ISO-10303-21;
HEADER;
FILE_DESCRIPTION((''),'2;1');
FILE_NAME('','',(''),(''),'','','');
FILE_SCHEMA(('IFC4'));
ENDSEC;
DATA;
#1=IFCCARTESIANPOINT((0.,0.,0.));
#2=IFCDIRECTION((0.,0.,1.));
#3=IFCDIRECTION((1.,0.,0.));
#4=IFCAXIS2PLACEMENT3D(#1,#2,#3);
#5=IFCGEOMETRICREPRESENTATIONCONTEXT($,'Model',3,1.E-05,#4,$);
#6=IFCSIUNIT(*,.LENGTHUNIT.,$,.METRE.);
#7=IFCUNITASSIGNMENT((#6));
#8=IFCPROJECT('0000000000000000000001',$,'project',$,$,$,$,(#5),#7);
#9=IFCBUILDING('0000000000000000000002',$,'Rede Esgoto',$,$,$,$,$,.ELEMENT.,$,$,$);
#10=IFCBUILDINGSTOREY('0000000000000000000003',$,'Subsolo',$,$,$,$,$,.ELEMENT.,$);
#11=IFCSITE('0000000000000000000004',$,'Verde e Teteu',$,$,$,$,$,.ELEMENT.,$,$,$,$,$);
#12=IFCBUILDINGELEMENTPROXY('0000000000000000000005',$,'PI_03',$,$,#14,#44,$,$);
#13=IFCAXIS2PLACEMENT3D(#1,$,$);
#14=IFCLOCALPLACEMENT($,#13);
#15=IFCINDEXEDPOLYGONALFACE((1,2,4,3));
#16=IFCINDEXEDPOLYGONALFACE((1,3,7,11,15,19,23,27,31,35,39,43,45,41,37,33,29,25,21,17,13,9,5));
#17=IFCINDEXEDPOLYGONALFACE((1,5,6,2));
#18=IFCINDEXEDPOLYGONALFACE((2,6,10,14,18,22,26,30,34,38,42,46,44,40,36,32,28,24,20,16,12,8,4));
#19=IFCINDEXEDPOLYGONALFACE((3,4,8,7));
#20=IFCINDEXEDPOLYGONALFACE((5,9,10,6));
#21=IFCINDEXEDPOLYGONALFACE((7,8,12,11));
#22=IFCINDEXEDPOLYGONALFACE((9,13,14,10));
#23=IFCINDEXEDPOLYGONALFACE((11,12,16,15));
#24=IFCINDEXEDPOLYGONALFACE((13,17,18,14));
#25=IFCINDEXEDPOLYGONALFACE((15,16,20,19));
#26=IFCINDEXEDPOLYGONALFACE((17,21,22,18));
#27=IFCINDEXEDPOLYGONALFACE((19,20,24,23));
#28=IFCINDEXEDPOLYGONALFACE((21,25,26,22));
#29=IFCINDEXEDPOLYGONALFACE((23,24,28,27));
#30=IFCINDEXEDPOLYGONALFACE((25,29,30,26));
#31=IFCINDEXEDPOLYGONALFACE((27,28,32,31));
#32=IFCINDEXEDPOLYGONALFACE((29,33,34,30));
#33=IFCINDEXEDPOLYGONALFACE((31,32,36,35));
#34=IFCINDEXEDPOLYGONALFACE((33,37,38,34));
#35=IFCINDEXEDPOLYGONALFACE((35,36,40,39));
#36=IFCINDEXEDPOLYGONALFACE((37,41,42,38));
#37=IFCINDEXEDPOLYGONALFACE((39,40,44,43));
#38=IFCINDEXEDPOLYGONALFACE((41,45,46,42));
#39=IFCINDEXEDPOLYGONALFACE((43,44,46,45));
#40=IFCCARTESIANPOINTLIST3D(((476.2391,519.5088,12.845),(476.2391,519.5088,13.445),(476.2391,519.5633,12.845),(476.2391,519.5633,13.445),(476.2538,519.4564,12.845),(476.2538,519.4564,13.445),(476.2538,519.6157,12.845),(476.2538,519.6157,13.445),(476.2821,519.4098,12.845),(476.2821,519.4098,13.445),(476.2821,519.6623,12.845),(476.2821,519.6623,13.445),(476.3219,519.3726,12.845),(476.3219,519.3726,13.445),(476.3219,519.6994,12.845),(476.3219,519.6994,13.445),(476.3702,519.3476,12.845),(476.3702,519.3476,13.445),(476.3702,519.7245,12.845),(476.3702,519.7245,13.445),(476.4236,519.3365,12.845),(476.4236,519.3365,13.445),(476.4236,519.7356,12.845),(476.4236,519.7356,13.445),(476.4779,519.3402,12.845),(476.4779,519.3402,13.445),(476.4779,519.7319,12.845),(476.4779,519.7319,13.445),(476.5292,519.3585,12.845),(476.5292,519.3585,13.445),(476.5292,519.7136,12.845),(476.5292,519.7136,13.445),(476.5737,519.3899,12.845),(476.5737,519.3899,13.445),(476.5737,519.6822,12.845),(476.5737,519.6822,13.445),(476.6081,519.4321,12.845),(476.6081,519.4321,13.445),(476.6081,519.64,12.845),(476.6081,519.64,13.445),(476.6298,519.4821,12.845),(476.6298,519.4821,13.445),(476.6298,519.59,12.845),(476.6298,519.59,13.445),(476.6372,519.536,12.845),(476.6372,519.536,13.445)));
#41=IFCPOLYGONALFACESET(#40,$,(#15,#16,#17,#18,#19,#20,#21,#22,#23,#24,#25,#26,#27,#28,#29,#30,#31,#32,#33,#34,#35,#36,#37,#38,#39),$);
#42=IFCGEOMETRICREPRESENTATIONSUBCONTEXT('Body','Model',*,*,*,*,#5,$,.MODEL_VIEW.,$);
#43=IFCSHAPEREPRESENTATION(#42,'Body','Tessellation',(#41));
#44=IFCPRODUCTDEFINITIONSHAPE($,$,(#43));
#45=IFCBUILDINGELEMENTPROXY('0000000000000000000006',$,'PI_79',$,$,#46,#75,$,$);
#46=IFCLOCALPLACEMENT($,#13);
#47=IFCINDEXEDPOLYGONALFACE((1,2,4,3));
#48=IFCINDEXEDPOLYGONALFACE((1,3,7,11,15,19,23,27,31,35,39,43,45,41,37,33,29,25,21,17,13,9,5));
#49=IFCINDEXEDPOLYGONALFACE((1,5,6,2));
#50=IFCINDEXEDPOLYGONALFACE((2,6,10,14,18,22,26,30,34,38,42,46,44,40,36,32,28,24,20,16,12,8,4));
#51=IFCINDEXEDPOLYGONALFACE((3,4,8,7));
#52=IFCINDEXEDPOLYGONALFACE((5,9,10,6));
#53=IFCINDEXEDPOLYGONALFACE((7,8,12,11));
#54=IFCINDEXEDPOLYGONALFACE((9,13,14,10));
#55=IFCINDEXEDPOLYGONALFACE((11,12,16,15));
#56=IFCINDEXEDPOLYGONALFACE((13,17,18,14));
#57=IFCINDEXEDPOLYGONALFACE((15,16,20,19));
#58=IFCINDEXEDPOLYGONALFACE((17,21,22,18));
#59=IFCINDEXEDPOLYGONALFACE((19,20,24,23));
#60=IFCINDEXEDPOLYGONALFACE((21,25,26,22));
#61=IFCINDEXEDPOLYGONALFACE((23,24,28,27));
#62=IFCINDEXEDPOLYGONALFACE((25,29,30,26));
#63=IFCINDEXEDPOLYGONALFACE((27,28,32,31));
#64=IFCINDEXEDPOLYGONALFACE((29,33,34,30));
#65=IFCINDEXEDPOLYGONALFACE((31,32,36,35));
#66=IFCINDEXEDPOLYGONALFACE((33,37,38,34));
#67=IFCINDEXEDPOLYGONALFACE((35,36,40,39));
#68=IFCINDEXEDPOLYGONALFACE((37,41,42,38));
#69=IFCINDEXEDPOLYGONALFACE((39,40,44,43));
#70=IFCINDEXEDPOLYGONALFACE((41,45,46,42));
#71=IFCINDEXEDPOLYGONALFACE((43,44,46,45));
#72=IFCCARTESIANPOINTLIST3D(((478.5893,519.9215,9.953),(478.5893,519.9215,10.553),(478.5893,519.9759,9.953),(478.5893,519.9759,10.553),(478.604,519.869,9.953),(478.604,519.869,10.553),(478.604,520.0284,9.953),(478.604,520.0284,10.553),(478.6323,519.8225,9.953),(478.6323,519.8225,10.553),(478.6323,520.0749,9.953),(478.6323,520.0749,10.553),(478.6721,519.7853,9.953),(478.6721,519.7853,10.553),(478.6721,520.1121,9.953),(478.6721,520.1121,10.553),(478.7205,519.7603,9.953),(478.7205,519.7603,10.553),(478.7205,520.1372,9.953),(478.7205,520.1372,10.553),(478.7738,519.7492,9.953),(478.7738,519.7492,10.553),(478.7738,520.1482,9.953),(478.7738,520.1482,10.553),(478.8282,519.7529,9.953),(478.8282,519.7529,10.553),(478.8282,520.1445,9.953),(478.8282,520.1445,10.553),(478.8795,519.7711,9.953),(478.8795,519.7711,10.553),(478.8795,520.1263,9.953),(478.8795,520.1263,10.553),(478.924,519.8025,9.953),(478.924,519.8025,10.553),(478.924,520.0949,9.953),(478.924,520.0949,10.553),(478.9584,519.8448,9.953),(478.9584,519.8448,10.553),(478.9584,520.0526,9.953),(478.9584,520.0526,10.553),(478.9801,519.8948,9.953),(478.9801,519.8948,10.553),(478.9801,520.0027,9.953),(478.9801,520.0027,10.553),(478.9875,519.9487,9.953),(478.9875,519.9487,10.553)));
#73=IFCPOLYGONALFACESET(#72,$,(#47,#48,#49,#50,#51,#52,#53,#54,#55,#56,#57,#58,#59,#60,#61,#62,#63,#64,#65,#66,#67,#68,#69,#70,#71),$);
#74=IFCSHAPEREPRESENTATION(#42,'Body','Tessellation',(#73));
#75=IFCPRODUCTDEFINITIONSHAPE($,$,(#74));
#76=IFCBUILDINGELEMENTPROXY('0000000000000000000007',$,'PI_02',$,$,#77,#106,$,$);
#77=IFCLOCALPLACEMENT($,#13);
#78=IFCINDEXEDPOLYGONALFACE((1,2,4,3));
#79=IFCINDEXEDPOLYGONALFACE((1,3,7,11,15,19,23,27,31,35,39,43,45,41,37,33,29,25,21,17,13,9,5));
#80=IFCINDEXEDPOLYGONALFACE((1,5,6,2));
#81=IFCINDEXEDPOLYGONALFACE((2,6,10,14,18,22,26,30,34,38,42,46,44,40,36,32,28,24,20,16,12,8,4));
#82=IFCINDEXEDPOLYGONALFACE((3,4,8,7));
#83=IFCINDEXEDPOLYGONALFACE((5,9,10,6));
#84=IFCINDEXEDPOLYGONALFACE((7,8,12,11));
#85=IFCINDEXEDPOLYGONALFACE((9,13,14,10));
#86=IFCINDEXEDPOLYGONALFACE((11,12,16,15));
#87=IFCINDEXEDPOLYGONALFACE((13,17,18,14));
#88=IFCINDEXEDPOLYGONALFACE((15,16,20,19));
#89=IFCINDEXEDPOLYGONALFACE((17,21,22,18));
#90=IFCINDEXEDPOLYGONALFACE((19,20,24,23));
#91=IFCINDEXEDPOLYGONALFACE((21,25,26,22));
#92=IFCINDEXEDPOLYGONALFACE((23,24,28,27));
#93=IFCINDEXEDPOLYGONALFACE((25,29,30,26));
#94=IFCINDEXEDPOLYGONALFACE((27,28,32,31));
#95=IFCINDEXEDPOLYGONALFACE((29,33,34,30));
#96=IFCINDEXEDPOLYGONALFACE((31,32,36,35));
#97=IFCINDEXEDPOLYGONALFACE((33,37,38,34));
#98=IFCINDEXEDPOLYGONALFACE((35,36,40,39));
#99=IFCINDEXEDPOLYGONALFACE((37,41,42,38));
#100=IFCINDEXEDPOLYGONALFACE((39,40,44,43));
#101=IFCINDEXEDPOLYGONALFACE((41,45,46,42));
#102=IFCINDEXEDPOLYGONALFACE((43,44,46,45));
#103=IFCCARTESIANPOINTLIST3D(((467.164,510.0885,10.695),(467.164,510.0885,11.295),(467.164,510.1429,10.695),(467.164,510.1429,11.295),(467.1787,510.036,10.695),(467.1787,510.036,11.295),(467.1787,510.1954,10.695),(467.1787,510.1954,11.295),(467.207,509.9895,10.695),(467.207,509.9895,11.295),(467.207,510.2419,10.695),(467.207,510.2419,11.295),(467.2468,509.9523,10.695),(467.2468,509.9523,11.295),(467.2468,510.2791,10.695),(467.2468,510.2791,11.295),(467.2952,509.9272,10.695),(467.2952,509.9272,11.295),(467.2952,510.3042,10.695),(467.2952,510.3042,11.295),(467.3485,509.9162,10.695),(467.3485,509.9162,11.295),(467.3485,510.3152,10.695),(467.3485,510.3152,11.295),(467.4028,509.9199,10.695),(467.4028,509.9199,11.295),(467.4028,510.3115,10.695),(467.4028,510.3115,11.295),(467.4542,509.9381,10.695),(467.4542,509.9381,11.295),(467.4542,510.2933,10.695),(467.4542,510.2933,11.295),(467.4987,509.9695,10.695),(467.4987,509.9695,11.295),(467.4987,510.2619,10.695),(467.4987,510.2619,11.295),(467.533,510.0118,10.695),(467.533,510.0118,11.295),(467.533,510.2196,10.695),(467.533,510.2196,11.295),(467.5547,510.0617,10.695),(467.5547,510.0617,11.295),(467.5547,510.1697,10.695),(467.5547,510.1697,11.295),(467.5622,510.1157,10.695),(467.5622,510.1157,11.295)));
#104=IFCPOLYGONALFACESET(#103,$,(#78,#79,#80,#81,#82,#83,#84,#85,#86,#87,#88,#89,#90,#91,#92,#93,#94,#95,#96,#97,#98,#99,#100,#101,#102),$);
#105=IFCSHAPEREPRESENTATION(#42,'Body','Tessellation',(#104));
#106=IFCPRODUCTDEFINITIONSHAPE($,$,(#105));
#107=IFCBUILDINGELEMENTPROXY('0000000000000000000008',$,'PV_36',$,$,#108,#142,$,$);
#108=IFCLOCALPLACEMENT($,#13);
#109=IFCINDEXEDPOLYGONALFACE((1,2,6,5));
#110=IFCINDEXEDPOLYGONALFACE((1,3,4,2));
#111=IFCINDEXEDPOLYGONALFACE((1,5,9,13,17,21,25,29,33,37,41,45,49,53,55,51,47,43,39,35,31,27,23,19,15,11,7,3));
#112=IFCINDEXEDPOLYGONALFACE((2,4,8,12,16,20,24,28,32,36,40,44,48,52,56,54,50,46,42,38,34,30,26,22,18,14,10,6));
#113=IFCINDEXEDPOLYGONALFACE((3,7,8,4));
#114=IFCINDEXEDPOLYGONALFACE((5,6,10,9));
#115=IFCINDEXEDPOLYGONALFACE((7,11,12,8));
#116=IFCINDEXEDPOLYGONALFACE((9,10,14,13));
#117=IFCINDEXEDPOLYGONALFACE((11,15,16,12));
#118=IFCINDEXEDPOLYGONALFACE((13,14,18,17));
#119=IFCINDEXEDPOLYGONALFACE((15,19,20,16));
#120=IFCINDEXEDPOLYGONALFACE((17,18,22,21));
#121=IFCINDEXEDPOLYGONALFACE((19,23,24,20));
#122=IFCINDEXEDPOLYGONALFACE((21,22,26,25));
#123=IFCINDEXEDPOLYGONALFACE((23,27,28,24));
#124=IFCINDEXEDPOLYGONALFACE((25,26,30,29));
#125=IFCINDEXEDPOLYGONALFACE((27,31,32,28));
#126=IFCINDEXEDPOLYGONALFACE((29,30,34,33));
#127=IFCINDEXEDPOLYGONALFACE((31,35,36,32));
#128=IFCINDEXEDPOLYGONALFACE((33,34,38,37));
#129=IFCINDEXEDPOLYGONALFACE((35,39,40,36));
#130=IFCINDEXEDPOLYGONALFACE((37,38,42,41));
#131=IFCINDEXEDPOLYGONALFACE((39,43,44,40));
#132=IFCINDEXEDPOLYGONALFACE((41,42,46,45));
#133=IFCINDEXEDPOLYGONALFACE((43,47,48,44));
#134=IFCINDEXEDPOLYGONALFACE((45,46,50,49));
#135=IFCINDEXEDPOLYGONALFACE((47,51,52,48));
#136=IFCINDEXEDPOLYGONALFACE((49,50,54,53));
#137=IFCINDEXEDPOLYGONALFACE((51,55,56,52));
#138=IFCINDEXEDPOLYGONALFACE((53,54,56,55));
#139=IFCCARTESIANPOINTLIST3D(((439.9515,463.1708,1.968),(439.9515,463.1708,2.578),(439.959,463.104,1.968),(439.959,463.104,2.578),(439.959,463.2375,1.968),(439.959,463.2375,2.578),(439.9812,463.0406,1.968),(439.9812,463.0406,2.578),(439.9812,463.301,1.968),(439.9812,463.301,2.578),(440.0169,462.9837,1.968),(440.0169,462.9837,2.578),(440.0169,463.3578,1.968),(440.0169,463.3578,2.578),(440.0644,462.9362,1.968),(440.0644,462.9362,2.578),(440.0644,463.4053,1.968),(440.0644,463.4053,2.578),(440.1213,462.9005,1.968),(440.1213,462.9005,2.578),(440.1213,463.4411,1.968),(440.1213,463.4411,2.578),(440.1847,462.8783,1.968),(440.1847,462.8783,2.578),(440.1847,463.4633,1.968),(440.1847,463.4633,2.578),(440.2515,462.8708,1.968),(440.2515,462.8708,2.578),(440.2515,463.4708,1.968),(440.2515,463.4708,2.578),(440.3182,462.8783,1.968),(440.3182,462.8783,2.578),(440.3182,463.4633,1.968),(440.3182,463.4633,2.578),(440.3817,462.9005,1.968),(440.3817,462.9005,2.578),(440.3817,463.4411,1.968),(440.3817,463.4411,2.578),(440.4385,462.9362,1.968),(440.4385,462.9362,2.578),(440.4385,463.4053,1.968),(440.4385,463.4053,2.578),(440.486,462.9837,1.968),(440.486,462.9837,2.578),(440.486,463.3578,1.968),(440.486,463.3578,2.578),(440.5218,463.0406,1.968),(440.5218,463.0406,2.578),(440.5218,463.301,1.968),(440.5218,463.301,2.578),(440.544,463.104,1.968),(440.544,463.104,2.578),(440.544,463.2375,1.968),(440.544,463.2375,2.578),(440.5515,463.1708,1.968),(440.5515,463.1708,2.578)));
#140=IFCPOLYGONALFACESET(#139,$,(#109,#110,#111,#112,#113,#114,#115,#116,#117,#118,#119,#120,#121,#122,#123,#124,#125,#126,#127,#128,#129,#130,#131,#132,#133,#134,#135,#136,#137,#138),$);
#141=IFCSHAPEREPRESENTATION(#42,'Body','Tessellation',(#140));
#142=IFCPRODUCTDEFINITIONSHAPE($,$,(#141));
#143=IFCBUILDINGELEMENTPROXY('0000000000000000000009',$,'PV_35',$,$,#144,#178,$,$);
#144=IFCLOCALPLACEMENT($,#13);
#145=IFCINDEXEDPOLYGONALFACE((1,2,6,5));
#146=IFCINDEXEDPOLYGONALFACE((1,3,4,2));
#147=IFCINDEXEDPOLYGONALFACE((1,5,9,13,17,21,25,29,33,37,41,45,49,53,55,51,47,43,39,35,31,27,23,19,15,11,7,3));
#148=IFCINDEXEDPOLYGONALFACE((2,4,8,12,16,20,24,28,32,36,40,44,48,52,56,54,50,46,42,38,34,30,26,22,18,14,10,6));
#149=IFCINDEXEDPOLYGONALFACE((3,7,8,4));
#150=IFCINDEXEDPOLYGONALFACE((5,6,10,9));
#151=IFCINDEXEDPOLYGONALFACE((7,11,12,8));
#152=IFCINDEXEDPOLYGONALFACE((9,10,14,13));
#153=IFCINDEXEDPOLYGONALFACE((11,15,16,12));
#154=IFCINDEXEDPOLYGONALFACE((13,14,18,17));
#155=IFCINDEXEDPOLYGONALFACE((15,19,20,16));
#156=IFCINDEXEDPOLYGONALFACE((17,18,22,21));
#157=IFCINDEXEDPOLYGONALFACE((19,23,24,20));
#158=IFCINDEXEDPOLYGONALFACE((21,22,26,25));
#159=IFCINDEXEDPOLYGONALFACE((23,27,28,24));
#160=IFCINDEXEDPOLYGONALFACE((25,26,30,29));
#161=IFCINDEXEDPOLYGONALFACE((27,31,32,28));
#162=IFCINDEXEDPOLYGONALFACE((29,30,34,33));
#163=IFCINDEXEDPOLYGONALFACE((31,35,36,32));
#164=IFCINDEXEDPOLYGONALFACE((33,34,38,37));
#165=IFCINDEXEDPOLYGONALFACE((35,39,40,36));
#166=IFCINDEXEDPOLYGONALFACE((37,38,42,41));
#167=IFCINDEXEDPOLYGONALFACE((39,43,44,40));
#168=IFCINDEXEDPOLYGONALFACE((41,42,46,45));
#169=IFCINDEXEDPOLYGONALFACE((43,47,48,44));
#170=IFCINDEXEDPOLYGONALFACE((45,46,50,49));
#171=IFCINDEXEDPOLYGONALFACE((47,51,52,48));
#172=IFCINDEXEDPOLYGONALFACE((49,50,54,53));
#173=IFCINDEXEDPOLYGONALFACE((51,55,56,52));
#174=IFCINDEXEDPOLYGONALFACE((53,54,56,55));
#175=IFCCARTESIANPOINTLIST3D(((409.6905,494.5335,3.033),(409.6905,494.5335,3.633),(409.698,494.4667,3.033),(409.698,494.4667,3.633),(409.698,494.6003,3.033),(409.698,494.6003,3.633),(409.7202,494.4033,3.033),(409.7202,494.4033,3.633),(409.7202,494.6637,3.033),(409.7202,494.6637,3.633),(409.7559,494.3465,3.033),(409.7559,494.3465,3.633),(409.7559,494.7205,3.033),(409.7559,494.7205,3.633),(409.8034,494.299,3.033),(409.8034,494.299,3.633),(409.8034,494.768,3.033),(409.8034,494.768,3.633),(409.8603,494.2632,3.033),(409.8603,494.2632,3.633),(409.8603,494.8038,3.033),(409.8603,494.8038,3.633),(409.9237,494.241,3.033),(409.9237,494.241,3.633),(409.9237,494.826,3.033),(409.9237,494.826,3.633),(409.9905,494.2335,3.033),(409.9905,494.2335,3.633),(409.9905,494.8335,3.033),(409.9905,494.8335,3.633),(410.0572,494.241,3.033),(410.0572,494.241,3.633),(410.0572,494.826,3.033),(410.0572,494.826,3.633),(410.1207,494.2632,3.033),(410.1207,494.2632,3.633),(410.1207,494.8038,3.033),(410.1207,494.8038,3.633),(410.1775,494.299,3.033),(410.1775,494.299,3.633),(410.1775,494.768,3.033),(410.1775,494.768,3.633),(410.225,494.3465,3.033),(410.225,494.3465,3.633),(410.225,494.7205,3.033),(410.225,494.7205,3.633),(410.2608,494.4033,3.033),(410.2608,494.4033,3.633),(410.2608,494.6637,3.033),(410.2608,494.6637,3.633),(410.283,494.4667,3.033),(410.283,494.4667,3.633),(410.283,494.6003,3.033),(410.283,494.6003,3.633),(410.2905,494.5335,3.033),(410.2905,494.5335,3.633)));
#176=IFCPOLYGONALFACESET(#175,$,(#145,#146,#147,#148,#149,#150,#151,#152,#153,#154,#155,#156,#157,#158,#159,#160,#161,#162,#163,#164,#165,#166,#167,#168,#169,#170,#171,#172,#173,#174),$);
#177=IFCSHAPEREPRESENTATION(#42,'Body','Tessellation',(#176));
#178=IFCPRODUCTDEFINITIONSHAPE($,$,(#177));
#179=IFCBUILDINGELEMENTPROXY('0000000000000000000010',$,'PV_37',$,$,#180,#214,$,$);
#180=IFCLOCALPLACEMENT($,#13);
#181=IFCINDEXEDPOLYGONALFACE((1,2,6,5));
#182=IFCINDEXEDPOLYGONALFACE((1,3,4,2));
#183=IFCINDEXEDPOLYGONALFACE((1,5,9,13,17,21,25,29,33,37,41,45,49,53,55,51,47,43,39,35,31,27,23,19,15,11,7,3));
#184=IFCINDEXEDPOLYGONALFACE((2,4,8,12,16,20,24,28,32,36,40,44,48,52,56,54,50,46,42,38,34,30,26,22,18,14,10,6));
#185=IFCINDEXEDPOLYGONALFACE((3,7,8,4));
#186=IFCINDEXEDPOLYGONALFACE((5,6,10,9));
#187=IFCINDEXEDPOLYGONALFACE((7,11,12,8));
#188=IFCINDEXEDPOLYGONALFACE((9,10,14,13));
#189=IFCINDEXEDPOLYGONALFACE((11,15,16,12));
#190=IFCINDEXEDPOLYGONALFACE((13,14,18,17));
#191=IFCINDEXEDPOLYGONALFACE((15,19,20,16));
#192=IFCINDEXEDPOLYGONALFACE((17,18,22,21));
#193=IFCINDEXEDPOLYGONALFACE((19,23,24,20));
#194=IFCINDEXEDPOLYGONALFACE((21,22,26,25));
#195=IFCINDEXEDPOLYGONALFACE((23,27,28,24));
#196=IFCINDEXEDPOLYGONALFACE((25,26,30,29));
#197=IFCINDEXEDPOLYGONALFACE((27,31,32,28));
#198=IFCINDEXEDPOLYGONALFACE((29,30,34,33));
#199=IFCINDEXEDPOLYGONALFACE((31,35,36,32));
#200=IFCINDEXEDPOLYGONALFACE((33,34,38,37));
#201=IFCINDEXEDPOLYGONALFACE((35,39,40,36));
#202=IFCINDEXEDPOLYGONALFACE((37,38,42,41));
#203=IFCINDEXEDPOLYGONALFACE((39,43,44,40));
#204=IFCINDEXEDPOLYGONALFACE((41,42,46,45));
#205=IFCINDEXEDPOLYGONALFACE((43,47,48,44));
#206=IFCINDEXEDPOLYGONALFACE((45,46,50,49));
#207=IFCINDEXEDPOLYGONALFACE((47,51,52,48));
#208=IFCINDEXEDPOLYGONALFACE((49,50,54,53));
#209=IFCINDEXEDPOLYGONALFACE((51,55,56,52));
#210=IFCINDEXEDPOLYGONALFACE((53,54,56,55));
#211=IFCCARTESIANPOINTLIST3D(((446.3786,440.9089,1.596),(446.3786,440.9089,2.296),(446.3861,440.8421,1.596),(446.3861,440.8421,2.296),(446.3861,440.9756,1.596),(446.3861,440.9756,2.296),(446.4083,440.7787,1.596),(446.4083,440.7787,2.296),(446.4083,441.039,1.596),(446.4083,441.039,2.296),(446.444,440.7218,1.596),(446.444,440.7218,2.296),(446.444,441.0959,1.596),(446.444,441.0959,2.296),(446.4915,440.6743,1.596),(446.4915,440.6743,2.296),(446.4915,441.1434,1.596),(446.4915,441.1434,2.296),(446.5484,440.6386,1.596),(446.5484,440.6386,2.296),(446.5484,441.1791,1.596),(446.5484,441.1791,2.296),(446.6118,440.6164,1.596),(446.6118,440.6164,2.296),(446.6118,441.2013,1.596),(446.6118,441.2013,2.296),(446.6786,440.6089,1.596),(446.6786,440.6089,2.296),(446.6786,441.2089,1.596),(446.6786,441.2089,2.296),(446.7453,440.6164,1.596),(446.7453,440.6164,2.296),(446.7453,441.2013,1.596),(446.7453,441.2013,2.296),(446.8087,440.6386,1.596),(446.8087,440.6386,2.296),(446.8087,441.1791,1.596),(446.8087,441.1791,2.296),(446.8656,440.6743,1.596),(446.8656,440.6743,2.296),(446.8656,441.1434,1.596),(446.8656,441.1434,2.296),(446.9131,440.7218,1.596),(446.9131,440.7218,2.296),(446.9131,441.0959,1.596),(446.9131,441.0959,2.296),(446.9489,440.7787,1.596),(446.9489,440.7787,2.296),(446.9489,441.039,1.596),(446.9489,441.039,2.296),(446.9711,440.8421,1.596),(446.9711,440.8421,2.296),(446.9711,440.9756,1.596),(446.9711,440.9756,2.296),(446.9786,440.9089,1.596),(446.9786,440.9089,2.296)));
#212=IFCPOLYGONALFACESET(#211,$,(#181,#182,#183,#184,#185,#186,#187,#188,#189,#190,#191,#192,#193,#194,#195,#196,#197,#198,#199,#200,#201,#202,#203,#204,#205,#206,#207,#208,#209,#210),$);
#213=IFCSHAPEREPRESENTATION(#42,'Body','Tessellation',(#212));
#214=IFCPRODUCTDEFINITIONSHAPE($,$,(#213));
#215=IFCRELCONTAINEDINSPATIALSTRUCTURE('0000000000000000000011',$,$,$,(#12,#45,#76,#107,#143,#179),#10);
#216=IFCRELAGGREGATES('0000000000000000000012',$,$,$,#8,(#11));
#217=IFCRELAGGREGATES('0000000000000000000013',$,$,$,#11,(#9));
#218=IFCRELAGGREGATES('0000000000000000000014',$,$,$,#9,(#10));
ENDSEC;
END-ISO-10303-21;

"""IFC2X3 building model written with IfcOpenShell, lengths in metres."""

from ifc_helpers import new_model, si_unit, frame, origin_with_axes, origin_2d, place, context, subcontext, project, spatial, circle, extrude, element, save


model = new_model("IFC2X3")

# Units and contexts
model_context = context("Model", 3, precision=1e-05, world=origin_with_axes())
body_context = subcontext(model_context, "Body", "Model", "MODEL_VIEW")
ifc_project = project(units=[si_unit("LENGTHUNIT", "METRE")], contexts=[model_context])

# Site, building, storey
site = spatial("IfcSite", under=ifc_project, Name="Verde e Teteu", CompositionType="ELEMENT")
building = spatial("IfcBuilding", under=site, Name="Rede Esgoto", CompositionType="ELEMENT")
storey = spatial("IfcBuildingStorey", under=building, Name="Subsolo", CompositionType="ELEMENT")

# Building element proxies
proxy_1_placement = place(None, frame((476.4372, 519.536, 12.845), z_axis=(0.0, 0.0, 1.0), x_axis=(1.0, 0.0, 0.0)))
element("IfcBuildingElementProxy", 1, at=proxy_1_placement, inside=storey, Name="PI_03", context=body_context, shape_type="SweptSolid", body=[
    extrude(circle(Radius=0.2, at=origin_2d()), origin_with_axes(), (0.0, 0.0, 1.0), 0.6),
])
proxy_2_placement = place(None, frame((478.7875, 519.9487, 9.953), z_axis=(0.0, 0.0, 1.0), x_axis=(1.0, 0.0, 0.0)))
element("IfcBuildingElementProxy", 2, at=proxy_2_placement, inside=storey, Name="PI_79", context=body_context, shape_type="SweptSolid", body=[
    extrude(circle(Radius=0.2, at=origin_2d()), origin_with_axes(), (0.0, 0.0, 1.0), 0.6),
])
proxy_3_placement = place(None, frame((467.3622, 510.1157, 10.695), z_axis=(0.0, 0.0, 1.0), x_axis=(1.0, 0.0, 0.0)))
element("IfcBuildingElementProxy", 3, at=proxy_3_placement, inside=storey, Name="PI_02", context=body_context, shape_type="SweptSolid", body=[
    extrude(circle(Radius=0.2, at=origin_2d()), origin_with_axes(), (0.0, 0.0, 1.0), 0.6),
])
proxy_4_placement = place(None, frame((440.2515, 463.1708, 1.968), z_axis=(0.0, 0.0, 1.0), x_axis=(1.0, 0.0, 0.0)))
element("IfcBuildingElementProxy", 4, at=proxy_4_placement, inside=storey, Name="PV_36", context=body_context, shape_type="SweptSolid", body=[
    extrude(circle(Radius=0.3, at=origin_2d()), origin_with_axes(), (0.0, 0.0, 1.0), 0.61),
])
proxy_5_placement = place(None, frame((409.9905, 494.5335, 3.033), z_axis=(0.0, 0.0, 1.0), x_axis=(1.0, 0.0, 0.0)))
element("IfcBuildingElementProxy", 5, at=proxy_5_placement, inside=storey, Name="PV_35", context=body_context, shape_type="SweptSolid", body=[
    extrude(circle(Radius=0.3, at=origin_2d()), origin_with_axes(), (0.0, 0.0, 1.0), 0.6),
])
proxy_6_placement = place(None, frame((446.6786, 440.9089, 1.596), z_axis=(0.0, 0.0, 1.0), x_axis=(1.0, 0.0, 0.0)))
element("IfcBuildingElementProxy", 6, at=proxy_6_placement, inside=storey, Name="PV_37", context=body_context, shape_type="SweptSolid", body=[
    extrude(circle(Radius=0.3, at=origin_2d()), origin_with_axes(), (0.0, 0.0, 1.0), 0.7),
])

save(model, "model.ifc")
